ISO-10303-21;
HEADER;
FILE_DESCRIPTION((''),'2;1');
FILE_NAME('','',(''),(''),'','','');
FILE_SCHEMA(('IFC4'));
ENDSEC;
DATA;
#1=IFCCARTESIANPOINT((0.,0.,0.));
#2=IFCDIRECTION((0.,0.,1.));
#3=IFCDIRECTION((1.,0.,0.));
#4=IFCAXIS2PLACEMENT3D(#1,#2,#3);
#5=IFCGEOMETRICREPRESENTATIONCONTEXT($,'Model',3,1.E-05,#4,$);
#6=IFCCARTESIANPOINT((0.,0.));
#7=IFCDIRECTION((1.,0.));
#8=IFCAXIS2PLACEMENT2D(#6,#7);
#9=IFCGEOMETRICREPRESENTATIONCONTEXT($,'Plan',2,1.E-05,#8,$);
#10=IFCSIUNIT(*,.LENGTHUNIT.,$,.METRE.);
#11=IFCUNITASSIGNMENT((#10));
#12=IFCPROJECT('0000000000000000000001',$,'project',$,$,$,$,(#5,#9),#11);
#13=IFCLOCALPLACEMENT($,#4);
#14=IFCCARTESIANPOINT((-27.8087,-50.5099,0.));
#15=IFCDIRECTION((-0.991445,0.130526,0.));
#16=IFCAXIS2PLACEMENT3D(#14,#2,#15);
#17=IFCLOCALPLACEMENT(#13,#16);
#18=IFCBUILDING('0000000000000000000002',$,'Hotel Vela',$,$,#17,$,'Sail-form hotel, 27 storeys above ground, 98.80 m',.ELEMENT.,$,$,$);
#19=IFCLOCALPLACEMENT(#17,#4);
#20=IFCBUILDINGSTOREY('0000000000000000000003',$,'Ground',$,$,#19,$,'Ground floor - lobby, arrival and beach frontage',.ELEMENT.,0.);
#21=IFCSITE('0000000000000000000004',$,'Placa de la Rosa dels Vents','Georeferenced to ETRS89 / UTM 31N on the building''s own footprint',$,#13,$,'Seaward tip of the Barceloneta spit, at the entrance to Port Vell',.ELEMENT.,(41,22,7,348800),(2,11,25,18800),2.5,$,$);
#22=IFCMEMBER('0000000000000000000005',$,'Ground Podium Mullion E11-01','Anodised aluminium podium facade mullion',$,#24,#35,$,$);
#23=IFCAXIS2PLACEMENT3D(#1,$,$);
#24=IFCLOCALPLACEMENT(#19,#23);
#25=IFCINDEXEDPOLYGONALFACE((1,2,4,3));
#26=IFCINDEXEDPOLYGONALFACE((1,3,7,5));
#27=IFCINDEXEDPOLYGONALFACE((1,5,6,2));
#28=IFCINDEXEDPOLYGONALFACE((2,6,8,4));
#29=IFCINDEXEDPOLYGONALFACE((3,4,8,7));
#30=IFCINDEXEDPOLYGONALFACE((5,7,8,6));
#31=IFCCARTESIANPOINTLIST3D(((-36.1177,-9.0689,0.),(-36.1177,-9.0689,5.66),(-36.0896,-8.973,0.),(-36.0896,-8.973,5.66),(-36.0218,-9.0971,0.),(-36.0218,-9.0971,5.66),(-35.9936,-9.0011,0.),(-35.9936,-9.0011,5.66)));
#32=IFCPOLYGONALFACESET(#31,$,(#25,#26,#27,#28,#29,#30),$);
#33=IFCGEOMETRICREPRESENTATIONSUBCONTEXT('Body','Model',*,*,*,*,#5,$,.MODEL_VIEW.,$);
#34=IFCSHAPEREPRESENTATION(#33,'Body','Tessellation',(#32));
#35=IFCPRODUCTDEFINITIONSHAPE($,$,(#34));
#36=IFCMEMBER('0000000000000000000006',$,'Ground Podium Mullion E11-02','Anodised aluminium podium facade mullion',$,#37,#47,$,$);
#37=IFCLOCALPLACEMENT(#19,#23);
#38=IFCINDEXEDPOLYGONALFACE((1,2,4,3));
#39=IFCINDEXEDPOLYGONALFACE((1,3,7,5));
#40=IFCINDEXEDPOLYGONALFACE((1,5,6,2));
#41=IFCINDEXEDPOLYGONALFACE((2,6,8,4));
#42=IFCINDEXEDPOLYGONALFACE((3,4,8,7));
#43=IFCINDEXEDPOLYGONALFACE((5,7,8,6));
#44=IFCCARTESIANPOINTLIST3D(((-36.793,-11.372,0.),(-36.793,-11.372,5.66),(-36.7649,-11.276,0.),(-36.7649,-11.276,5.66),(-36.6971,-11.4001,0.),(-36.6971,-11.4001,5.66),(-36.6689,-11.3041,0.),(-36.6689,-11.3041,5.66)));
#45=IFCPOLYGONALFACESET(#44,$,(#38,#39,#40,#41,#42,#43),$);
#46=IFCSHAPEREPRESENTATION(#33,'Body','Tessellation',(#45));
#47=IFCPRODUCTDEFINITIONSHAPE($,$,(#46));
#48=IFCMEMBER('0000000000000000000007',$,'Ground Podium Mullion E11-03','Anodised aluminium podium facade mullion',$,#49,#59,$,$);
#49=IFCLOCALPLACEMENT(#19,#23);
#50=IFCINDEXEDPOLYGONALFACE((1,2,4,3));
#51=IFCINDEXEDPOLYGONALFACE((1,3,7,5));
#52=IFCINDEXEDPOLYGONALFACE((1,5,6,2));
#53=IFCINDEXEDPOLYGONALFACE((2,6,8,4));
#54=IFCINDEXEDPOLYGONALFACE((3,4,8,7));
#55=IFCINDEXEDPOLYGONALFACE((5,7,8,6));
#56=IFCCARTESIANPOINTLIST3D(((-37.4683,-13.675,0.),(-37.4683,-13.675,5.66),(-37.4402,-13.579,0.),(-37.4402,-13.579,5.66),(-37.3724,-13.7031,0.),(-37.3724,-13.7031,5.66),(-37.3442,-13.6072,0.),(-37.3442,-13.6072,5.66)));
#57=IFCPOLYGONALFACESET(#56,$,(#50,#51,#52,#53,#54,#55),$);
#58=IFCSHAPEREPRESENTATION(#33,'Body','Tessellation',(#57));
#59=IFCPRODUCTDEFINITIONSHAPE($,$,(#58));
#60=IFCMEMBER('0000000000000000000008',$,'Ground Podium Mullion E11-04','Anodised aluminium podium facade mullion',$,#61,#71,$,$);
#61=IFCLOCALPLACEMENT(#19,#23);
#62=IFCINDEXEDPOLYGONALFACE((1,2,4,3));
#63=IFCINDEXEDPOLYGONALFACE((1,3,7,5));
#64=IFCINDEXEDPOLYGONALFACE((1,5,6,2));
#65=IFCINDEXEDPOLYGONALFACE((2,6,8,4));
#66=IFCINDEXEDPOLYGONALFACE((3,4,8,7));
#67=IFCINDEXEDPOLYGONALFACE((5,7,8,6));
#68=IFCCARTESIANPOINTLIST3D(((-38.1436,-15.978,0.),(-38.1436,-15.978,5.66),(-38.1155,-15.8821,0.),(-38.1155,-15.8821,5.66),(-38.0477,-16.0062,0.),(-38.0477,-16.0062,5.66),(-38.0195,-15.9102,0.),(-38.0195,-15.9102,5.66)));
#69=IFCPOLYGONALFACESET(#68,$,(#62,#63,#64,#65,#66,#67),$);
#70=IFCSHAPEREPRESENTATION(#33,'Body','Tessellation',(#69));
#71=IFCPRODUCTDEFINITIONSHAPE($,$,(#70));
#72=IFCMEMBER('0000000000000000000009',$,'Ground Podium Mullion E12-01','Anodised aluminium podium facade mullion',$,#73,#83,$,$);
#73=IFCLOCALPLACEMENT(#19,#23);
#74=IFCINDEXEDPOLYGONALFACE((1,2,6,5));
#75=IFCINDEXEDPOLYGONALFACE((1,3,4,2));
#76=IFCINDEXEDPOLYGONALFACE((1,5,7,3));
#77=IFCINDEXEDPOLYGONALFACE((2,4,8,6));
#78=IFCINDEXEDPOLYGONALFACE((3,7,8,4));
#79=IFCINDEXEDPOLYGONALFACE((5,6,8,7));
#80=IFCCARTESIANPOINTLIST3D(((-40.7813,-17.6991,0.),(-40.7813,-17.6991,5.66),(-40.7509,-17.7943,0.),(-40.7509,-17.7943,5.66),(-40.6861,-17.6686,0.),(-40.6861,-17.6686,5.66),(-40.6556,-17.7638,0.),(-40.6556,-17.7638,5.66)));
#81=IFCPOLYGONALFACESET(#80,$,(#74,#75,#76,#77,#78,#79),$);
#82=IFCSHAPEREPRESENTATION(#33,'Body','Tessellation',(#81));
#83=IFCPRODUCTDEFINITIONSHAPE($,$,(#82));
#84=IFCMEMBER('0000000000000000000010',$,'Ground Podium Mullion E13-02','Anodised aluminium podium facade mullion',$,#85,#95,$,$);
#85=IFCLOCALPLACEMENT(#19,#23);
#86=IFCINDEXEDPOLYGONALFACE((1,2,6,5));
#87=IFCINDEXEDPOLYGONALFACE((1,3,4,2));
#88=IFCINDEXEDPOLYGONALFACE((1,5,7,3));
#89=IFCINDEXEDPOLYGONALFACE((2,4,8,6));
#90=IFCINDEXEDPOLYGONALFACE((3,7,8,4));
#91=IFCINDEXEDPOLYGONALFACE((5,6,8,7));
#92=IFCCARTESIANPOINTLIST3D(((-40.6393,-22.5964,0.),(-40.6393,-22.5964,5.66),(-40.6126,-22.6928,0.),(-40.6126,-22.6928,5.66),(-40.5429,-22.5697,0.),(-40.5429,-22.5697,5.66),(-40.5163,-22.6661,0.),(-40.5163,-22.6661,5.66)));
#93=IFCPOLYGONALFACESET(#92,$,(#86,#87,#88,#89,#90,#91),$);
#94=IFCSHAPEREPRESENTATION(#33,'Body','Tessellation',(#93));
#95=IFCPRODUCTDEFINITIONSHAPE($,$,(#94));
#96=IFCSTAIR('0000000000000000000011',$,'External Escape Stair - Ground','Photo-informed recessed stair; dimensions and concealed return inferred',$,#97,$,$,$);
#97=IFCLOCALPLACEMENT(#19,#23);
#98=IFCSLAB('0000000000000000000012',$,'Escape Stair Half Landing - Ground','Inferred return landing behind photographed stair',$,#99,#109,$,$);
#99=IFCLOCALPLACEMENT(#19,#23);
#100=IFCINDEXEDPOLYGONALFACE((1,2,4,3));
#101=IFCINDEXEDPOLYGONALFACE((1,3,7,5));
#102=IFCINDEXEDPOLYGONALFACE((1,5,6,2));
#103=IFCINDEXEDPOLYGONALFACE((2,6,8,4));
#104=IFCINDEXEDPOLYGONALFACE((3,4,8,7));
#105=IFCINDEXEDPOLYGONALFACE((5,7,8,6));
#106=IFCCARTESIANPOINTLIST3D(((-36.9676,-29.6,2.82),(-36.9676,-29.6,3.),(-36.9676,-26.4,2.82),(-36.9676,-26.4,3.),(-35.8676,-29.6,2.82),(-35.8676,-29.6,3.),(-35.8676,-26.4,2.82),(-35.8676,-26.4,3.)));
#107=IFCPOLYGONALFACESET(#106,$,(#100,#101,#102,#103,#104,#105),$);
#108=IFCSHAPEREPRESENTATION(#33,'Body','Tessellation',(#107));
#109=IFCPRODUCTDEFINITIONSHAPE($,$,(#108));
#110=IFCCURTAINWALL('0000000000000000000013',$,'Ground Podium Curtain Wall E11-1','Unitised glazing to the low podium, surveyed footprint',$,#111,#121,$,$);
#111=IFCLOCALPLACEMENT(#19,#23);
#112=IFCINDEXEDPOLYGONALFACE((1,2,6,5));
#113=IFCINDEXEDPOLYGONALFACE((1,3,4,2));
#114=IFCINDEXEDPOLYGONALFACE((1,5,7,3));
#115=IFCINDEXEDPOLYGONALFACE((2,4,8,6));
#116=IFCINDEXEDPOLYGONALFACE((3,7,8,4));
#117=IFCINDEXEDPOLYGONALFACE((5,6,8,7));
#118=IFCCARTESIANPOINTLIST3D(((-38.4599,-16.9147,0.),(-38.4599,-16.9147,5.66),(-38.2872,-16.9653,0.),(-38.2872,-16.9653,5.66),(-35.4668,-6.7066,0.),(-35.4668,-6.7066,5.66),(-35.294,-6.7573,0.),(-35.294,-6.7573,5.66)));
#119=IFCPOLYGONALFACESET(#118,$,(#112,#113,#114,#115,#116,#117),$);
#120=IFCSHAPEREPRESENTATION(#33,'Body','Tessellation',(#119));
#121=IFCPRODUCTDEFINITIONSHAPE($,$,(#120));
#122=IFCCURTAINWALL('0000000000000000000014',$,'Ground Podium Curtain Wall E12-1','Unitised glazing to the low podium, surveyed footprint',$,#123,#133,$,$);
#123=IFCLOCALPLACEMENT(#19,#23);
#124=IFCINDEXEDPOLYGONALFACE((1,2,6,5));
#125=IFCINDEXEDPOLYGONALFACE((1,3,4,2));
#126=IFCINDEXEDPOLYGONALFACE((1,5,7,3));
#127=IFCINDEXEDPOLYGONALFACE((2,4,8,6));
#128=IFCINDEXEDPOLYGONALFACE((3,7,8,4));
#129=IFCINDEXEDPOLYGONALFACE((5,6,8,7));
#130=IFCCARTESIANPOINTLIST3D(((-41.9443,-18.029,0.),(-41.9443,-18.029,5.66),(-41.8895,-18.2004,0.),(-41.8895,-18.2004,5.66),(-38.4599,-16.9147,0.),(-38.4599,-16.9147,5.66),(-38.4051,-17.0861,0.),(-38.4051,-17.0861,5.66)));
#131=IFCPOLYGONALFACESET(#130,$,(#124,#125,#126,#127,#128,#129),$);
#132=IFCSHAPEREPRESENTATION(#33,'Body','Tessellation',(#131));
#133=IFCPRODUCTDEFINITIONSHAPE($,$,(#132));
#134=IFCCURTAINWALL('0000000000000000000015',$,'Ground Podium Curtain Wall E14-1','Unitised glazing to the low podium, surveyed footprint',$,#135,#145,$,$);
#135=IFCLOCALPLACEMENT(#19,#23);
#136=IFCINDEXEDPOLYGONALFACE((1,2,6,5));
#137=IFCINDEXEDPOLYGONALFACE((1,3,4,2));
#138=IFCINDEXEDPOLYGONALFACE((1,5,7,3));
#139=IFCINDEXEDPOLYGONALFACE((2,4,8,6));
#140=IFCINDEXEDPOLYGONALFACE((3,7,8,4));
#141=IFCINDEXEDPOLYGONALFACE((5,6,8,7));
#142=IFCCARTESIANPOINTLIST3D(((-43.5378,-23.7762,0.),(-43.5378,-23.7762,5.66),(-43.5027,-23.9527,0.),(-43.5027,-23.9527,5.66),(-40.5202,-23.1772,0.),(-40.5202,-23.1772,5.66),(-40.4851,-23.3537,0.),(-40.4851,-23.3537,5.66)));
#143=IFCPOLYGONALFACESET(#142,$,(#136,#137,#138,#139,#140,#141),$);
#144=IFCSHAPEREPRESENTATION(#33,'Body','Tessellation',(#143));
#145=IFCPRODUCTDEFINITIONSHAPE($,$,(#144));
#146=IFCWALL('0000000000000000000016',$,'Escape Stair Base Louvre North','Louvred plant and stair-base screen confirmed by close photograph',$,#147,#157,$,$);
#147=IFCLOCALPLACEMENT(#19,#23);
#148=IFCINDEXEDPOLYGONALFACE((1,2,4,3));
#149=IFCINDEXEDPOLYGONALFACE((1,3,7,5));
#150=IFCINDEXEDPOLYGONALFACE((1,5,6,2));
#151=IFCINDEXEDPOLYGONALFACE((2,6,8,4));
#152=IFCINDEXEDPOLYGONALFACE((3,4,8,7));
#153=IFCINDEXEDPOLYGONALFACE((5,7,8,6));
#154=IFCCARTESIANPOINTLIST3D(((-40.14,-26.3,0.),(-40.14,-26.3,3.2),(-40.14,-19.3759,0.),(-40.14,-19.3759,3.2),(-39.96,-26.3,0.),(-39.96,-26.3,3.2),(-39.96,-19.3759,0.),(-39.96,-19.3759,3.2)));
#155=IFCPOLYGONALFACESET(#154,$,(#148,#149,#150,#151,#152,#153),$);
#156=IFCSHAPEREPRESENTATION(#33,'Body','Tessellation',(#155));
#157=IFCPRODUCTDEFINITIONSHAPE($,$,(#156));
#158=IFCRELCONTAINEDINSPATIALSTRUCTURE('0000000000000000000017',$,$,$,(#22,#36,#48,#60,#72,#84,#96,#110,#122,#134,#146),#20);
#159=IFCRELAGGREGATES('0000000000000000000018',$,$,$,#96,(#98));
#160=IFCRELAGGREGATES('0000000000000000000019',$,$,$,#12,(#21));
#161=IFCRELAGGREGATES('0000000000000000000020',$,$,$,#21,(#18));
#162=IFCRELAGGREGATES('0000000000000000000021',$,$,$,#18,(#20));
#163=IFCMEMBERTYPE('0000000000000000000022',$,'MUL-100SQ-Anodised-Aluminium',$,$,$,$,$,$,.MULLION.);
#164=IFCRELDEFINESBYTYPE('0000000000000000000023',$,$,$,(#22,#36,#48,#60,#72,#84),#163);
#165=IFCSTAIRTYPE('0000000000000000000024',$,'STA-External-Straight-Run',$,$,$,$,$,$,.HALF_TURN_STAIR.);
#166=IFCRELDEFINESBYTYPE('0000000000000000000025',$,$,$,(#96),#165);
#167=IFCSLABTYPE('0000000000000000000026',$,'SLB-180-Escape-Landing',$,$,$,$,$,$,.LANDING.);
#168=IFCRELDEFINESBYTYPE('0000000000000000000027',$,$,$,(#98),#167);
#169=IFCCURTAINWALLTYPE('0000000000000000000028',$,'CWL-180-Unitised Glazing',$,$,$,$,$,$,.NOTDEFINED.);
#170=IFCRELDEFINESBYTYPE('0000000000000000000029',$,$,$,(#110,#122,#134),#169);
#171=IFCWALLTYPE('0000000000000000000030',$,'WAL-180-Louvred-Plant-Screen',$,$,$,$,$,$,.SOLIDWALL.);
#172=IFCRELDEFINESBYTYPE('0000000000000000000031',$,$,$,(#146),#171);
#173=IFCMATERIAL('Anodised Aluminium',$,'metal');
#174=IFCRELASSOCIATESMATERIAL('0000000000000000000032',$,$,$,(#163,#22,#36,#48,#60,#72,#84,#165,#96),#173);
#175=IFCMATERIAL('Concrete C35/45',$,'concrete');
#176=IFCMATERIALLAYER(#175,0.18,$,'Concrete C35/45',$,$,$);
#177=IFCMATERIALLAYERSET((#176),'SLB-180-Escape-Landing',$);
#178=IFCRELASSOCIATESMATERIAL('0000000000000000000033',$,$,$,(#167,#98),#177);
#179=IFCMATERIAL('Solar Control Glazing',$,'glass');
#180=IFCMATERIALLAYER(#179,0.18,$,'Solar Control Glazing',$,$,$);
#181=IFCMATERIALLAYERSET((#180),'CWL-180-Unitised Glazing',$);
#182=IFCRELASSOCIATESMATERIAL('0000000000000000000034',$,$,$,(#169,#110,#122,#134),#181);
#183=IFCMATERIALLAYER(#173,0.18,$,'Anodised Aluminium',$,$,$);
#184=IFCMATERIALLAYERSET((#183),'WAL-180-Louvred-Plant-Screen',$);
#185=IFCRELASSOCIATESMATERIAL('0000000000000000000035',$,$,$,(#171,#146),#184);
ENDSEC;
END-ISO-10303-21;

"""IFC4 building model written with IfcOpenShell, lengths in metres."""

from ifc_helpers import new_model, si_unit, frame, origin_with_axes, origin_2d_with_axis, place, context, subcontext, project, spatial, line, indexed_curve, rectangle, outline, extrude, material, layer, layer_set, layer_usage, material_profile, profile_set, profile_usage, type_object, element, aggregate, save


model = new_model("IFC4")

# Units and contexts
model_context = context("Model", 3, precision=1e-05, world=origin_with_axes())
plan_context = context("Plan", 2, precision=1e-05, world=origin_2d_with_axis())
body_context = subcontext(model_context, "Body", "Model", "MODEL_VIEW")
ifc_project = project(units=[si_unit("LENGTHUNIT", "METRE")], contexts=[model_context, plan_context])

# Site, building, storey
site_placement = place(None, origin_with_axes())
site = spatial("IfcSite", under=ifc_project, at=site_placement, Name="Placa de la Rosa dels Vents", Description="Georeferenced to ETRS89 / UTM 31N on the building's own footprint", LongName="Seaward tip of the Barceloneta spit, at the entrance to Port Vell", CompositionType="ELEMENT", RefLatitude=(41, 22, 7, 348800), RefLongitude=(2, 11, 25, 18800), RefElevation=2.5)
building_placement = place(site_placement, frame((-27.8087, -50.5099, 0.0), z_axis=(0.0, 0.0, 1.0), x_axis=(-0.991445, 0.130526, 0.0)))
building = spatial("IfcBuilding", under=site, at=building_placement, Name="Hotel Vela", LongName="Sail-form hotel, 27 storeys above ground, 98.80 m", CompositionType="ELEMENT")
storey_placement = place(building_placement, origin_with_axes())
storey = spatial("IfcBuildingStorey", under=building, at=storey_placement, Name="Ground", LongName="Ground floor - lobby, arrival and beach frontage", CompositionType="ELEMENT", Elevation=0.0)

# Members
ifc_material_1 = material(Name="Anodised Aluminium", Category="metal")
ifc_material_profile = material_profile(ifc_material_1, rectangle(XDim=0.1, YDim=0.1))
ifc_profile_set = profile_set([ifc_material_profile], Name="MUL-100SQ-Anodised-Aluminium")
member_type = type_object("IfcMemberType", Name="MUL-100SQ-Anodised-Aluminium", PredefinedType="MULLION", material=ifc_profile_set)
ifc_profile_usage_1 = profile_usage(ifc_profile_set)
member_1_placement = place(storey_placement, frame((-36.0896, -8.973, 0.0), z_axis=(0.0, 0.0, 1.0), x_axis=(-0.281373, -0.959598, 0.0)))
element("IfcMember", 1, at=member_1_placement, inside=storey, type_object=member_type, material=ifc_profile_usage_1, Name="Ground Podium Mullion E11-01", Description="Anodised aluminium podium facade mullion", context=body_context, shape_type="SweptSolid", body=[
    extrude(outline(indexed_curve([(0.0, 0.0), (0.1, 0.0), (0.1, 0.1), (0.0, 0.1)], segments=[line(1, 2, 3, 4, 1)])), origin_with_axes(), (0.0, 0.0, 1.0), 5.66),
])
ifc_profile_usage_2 = profile_usage(ifc_profile_set)
member_2_placement = place(storey_placement, frame((-36.7649, -11.276, 0.0), z_axis=(0.0, 0.0, 1.0), x_axis=(-0.281373, -0.959598, 0.0)))
element("IfcMember", 2, at=member_2_placement, inside=storey, type_object=member_type, material=ifc_profile_usage_2, Name="Ground Podium Mullion E11-02", Description="Anodised aluminium podium facade mullion", context=body_context, shape_type="SweptSolid", body=[
    extrude(outline(indexed_curve([(0.0, 0.0), (0.1, 0.0), (0.1, 0.1), (0.0, 0.1)], segments=[line(1, 2, 3, 4, 1)])), origin_with_axes(), (0.0, 0.0, 1.0), 5.66),
])
ifc_profile_usage_3 = profile_usage(ifc_profile_set)
member_3_placement = place(storey_placement, frame((-37.4402, -13.579, 0.0), z_axis=(0.0, 0.0, 1.0), x_axis=(-0.281373, -0.959598, 0.0)))
element("IfcMember", 3, at=member_3_placement, inside=storey, type_object=member_type, material=ifc_profile_usage_3, Name="Ground Podium Mullion E11-03", Description="Anodised aluminium podium facade mullion", context=body_context, shape_type="SweptSolid", body=[
    extrude(outline(indexed_curve([(0.0, 0.0), (0.1, 0.0), (0.1, 0.1), (0.0, 0.1)], segments=[line(1, 2, 3, 4, 1)])), origin_with_axes(), (0.0, 0.0, 1.0), 5.66),
])
ifc_profile_usage_4 = profile_usage(ifc_profile_set)
member_4_placement = place(storey_placement, frame((-38.1155, -15.8821, 0.0), z_axis=(0.0, 0.0, 1.0), x_axis=(-0.281373, -0.959598, 0.0)))
element("IfcMember", 4, at=member_4_placement, inside=storey, type_object=member_type, material=ifc_profile_usage_4, Name="Ground Podium Mullion E11-04", Description="Anodised aluminium podium facade mullion", context=body_context, shape_type="SweptSolid", body=[
    extrude(outline(indexed_curve([(0.0, 0.0), (0.1, 0.0), (0.1, 0.1), (0.0, 0.1)], segments=[line(1, 2, 3, 4, 1)])), origin_with_axes(), (0.0, 0.0, 1.0), 5.66),
])
ifc_profile_usage_5 = profile_usage(ifc_profile_set)
member_5_placement = place(storey_placement, frame((-40.6861, -17.6686, 0.0), z_axis=(0.0, 0.0, 1.0), x_axis=(-0.952477, -0.304612, 0.0)))
element("IfcMember", 5, at=member_5_placement, inside=storey, type_object=member_type, material=ifc_profile_usage_5, Name="Ground Podium Mullion E12-01", Description="Anodised aluminium podium facade mullion", context=body_context, shape_type="SweptSolid", body=[
    extrude(outline(indexed_curve([(0.0, 0.0), (0.1, 0.0), (0.1, 0.1), (0.0, 0.1)], segments=[line(1, 2, 3, 4, 1)])), origin_with_axes(), (0.0, 0.0, 1.0), 5.66),
])
ifc_profile_usage_6 = profile_usage(ifc_profile_set)
member_6_placement = place(storey_placement, frame((-40.6393, -22.5964, 0.0), z_axis=(0.0, 0.0, 1.0), x_axis=(0.26662, -0.963802, 0.0)))
element("IfcMember", 6, at=member_6_placement, inside=storey, type_object=member_type, material=ifc_profile_usage_6, Name="Ground Podium Mullion E13-02", Description="Anodised aluminium podium facade mullion", context=body_context, shape_type="SweptSolid", body=[
    extrude(outline(indexed_curve([(0.0, 0.0), (0.1, 0.0), (0.1, 0.1), (0.0, 0.1)], segments=[line(1, 2, 3, 4, 1)])), origin_with_axes(), (0.0, 0.0, 1.0), 5.66),
])

# Stair, slab
stair_type = type_object("IfcStairType", Name="STA-External-Straight-Run", PredefinedType="HALF_TURN_STAIR", material=ifc_material_1)
stair_placement = place(storey_placement, origin_with_axes())
stair = element("IfcStair", 7, at=stair_placement, inside=storey, type_object=stair_type, material=ifc_material_1, Name="External Escape Stair - Ground", Description="Photo-informed recessed stair; dimensions and concealed return inferred")
ifc_material_2 = material(Name="Concrete C35/45", Category="concrete")
ifc_layer_1 = layer(ifc_material_2, 0.18, Name="Concrete C35/45")
ifc_layer_set_1 = layer_set([ifc_layer_1], Name="SLB-180-Escape-Landing")
ifc_layer_usage_1 = layer_usage(ifc_layer_set_1, "AXIS3", "POSITIVE", 0.0)
slab_type = type_object("IfcSlabType", Name="SLB-180-Escape-Landing", PredefinedType="LANDING", material=ifc_layer_set_1)
slab_placement = place(stair_placement, frame((-36.9676, -29.6, 2.82), z_axis=(0.0, 0.0, 1.0), x_axis=(1.0, 0.0, 0.0)))
slab = element("IfcSlab", 8, at=slab_placement, type_object=slab_type, material=ifc_layer_usage_1, Name="Escape Stair Half Landing - Ground", Description="Inferred return landing behind photographed stair", context=body_context, shape_type="SweptSolid", body=[
    extrude(outline(indexed_curve([(0.0, 0.0), (1.1, 0.0), (1.1, 3.2), (0.0, 3.2)], segments=[line(1, 2, 3, 4, 1)])), origin_with_axes(), (0.0, 0.0, 1.0), 0.18),
])
aggregate(stair, [slab])

# Curtain walls
ifc_material_3 = material(Name="Solar Control Glazing", Category="glass")
ifc_layer_2 = layer(ifc_material_3, 0.18, Name="Solar Control Glazing")
ifc_layer_set_2 = layer_set([ifc_layer_2], Name="CWL-180-Unitised Glazing")
ifc_layer_usage_2 = layer_usage(ifc_layer_set_2, "AXIS2", "POSITIVE", 0.0)
curtain_wall_type = type_object("IfcCurtainWallType", Name="CWL-180-Unitised Glazing", PredefinedType="NOTDEFINED", material=ifc_layer_set_2)
curtain_wall_1_placement = place(storey_placement, frame((-35.4668, -6.7066, 0.0), z_axis=(0.0, 0.0, 1.0), x_axis=(-0.281373, -0.959598, 0.0)))
element("IfcCurtainWall", 9, at=curtain_wall_1_placement, inside=storey, type_object=curtain_wall_type, material=ifc_layer_usage_2, Name="Ground Podium Curtain Wall E11-1", Description="Unitised glazing to the low podium, surveyed footprint", context=body_context, shape_type="SweptSolid", body=[
    extrude(outline(indexed_curve([(0.0, 0.0), (10.6378, 0.0), (10.6378, 0.18), (0.0, 0.18)], segments=[line(1, 2, 3, 4, 1)])), origin_with_axes(), (0.0, 0.0, 1.0), 5.66),
])
ifc_layer_usage_3 = layer_usage(ifc_layer_set_2, "AXIS2", "POSITIVE", 0.0)
curtain_wall_2_placement = place(storey_placement, frame((-38.4599, -16.9147, 0.0), z_axis=(0.0, 0.0, 1.0), x_axis=(-0.952477, -0.304612, 0.0)))
element("IfcCurtainWall", 10, at=curtain_wall_2_placement, inside=storey, type_object=curtain_wall_type, material=ifc_layer_usage_3, Name="Ground Podium Curtain Wall E12-1", Description="Unitised glazing to the low podium, surveyed footprint", context=body_context, shape_type="SweptSolid", body=[
    extrude(outline(indexed_curve([(0.0, 0.0), (3.6582, 0.0), (3.6582, 0.18), (0.0, 0.18)], segments=[line(1, 2, 3, 4, 1)])), origin_with_axes(), (0.0, 0.0, 1.0), 5.66),
])
ifc_layer_usage_4 = layer_usage(ifc_layer_set_2, "AXIS2", "POSITIVE", 0.0)
curtain_wall_3_placement = place(storey_placement, frame((-40.5202, -23.1772, 0.0), z_axis=(0.0, 0.0, 1.0), x_axis=(-0.980862, -0.194703, 0.0)))
element("IfcCurtainWall", 11, at=curtain_wall_3_placement, inside=storey, type_object=curtain_wall_type, material=ifc_layer_usage_4, Name="Ground Podium Curtain Wall E14-1", Description="Unitised glazing to the low podium, surveyed footprint", context=body_context, shape_type="SweptSolid", body=[
    extrude(outline(indexed_curve([(0.0, 0.0), (3.0765, 0.0), (3.0765, 0.18), (0.0, 0.18)], segments=[line(1, 2, 3, 4, 1)])), origin_with_axes(), (0.0, 0.0, 1.0), 5.66),
])

# Wall
ifc_layer_3 = layer(ifc_material_1, 0.18, Name="Anodised Aluminium")
ifc_layer_set_3 = layer_set([ifc_layer_3], Name="WAL-180-Louvred-Plant-Screen")
ifc_layer_usage_5 = layer_usage(ifc_layer_set_3, "AXIS2", "POSITIVE", 0.0)
wall_type = type_object("IfcWallType", Name="WAL-180-Louvred-Plant-Screen", PredefinedType="SOLIDWALL", material=ifc_layer_set_3)
wall_placement = place(storey_placement, frame((-39.96, -26.3, 0.0), z_axis=(0.0, 0.0, 1.0), x_axis=(0.0, 1.0, 0.0)))
element("IfcWall", 12, at=wall_placement, inside=storey, type_object=wall_type, material=ifc_layer_usage_5, Name="Escape Stair Base Louvre North", Description="Louvred plant and stair-base screen confirmed by close photograph", context=body_context, shape_type="SweptSolid", body=[
    extrude(outline(indexed_curve([(0.0, 0.0), (6.9241, 0.0), (6.9241, 0.18), (0.0, 0.18)], segments=[line(1, 2, 3, 4, 1)])), origin_with_axes(), (0.0, 0.0, 1.0), 3.2),
])

save(model, "model.ifc")
